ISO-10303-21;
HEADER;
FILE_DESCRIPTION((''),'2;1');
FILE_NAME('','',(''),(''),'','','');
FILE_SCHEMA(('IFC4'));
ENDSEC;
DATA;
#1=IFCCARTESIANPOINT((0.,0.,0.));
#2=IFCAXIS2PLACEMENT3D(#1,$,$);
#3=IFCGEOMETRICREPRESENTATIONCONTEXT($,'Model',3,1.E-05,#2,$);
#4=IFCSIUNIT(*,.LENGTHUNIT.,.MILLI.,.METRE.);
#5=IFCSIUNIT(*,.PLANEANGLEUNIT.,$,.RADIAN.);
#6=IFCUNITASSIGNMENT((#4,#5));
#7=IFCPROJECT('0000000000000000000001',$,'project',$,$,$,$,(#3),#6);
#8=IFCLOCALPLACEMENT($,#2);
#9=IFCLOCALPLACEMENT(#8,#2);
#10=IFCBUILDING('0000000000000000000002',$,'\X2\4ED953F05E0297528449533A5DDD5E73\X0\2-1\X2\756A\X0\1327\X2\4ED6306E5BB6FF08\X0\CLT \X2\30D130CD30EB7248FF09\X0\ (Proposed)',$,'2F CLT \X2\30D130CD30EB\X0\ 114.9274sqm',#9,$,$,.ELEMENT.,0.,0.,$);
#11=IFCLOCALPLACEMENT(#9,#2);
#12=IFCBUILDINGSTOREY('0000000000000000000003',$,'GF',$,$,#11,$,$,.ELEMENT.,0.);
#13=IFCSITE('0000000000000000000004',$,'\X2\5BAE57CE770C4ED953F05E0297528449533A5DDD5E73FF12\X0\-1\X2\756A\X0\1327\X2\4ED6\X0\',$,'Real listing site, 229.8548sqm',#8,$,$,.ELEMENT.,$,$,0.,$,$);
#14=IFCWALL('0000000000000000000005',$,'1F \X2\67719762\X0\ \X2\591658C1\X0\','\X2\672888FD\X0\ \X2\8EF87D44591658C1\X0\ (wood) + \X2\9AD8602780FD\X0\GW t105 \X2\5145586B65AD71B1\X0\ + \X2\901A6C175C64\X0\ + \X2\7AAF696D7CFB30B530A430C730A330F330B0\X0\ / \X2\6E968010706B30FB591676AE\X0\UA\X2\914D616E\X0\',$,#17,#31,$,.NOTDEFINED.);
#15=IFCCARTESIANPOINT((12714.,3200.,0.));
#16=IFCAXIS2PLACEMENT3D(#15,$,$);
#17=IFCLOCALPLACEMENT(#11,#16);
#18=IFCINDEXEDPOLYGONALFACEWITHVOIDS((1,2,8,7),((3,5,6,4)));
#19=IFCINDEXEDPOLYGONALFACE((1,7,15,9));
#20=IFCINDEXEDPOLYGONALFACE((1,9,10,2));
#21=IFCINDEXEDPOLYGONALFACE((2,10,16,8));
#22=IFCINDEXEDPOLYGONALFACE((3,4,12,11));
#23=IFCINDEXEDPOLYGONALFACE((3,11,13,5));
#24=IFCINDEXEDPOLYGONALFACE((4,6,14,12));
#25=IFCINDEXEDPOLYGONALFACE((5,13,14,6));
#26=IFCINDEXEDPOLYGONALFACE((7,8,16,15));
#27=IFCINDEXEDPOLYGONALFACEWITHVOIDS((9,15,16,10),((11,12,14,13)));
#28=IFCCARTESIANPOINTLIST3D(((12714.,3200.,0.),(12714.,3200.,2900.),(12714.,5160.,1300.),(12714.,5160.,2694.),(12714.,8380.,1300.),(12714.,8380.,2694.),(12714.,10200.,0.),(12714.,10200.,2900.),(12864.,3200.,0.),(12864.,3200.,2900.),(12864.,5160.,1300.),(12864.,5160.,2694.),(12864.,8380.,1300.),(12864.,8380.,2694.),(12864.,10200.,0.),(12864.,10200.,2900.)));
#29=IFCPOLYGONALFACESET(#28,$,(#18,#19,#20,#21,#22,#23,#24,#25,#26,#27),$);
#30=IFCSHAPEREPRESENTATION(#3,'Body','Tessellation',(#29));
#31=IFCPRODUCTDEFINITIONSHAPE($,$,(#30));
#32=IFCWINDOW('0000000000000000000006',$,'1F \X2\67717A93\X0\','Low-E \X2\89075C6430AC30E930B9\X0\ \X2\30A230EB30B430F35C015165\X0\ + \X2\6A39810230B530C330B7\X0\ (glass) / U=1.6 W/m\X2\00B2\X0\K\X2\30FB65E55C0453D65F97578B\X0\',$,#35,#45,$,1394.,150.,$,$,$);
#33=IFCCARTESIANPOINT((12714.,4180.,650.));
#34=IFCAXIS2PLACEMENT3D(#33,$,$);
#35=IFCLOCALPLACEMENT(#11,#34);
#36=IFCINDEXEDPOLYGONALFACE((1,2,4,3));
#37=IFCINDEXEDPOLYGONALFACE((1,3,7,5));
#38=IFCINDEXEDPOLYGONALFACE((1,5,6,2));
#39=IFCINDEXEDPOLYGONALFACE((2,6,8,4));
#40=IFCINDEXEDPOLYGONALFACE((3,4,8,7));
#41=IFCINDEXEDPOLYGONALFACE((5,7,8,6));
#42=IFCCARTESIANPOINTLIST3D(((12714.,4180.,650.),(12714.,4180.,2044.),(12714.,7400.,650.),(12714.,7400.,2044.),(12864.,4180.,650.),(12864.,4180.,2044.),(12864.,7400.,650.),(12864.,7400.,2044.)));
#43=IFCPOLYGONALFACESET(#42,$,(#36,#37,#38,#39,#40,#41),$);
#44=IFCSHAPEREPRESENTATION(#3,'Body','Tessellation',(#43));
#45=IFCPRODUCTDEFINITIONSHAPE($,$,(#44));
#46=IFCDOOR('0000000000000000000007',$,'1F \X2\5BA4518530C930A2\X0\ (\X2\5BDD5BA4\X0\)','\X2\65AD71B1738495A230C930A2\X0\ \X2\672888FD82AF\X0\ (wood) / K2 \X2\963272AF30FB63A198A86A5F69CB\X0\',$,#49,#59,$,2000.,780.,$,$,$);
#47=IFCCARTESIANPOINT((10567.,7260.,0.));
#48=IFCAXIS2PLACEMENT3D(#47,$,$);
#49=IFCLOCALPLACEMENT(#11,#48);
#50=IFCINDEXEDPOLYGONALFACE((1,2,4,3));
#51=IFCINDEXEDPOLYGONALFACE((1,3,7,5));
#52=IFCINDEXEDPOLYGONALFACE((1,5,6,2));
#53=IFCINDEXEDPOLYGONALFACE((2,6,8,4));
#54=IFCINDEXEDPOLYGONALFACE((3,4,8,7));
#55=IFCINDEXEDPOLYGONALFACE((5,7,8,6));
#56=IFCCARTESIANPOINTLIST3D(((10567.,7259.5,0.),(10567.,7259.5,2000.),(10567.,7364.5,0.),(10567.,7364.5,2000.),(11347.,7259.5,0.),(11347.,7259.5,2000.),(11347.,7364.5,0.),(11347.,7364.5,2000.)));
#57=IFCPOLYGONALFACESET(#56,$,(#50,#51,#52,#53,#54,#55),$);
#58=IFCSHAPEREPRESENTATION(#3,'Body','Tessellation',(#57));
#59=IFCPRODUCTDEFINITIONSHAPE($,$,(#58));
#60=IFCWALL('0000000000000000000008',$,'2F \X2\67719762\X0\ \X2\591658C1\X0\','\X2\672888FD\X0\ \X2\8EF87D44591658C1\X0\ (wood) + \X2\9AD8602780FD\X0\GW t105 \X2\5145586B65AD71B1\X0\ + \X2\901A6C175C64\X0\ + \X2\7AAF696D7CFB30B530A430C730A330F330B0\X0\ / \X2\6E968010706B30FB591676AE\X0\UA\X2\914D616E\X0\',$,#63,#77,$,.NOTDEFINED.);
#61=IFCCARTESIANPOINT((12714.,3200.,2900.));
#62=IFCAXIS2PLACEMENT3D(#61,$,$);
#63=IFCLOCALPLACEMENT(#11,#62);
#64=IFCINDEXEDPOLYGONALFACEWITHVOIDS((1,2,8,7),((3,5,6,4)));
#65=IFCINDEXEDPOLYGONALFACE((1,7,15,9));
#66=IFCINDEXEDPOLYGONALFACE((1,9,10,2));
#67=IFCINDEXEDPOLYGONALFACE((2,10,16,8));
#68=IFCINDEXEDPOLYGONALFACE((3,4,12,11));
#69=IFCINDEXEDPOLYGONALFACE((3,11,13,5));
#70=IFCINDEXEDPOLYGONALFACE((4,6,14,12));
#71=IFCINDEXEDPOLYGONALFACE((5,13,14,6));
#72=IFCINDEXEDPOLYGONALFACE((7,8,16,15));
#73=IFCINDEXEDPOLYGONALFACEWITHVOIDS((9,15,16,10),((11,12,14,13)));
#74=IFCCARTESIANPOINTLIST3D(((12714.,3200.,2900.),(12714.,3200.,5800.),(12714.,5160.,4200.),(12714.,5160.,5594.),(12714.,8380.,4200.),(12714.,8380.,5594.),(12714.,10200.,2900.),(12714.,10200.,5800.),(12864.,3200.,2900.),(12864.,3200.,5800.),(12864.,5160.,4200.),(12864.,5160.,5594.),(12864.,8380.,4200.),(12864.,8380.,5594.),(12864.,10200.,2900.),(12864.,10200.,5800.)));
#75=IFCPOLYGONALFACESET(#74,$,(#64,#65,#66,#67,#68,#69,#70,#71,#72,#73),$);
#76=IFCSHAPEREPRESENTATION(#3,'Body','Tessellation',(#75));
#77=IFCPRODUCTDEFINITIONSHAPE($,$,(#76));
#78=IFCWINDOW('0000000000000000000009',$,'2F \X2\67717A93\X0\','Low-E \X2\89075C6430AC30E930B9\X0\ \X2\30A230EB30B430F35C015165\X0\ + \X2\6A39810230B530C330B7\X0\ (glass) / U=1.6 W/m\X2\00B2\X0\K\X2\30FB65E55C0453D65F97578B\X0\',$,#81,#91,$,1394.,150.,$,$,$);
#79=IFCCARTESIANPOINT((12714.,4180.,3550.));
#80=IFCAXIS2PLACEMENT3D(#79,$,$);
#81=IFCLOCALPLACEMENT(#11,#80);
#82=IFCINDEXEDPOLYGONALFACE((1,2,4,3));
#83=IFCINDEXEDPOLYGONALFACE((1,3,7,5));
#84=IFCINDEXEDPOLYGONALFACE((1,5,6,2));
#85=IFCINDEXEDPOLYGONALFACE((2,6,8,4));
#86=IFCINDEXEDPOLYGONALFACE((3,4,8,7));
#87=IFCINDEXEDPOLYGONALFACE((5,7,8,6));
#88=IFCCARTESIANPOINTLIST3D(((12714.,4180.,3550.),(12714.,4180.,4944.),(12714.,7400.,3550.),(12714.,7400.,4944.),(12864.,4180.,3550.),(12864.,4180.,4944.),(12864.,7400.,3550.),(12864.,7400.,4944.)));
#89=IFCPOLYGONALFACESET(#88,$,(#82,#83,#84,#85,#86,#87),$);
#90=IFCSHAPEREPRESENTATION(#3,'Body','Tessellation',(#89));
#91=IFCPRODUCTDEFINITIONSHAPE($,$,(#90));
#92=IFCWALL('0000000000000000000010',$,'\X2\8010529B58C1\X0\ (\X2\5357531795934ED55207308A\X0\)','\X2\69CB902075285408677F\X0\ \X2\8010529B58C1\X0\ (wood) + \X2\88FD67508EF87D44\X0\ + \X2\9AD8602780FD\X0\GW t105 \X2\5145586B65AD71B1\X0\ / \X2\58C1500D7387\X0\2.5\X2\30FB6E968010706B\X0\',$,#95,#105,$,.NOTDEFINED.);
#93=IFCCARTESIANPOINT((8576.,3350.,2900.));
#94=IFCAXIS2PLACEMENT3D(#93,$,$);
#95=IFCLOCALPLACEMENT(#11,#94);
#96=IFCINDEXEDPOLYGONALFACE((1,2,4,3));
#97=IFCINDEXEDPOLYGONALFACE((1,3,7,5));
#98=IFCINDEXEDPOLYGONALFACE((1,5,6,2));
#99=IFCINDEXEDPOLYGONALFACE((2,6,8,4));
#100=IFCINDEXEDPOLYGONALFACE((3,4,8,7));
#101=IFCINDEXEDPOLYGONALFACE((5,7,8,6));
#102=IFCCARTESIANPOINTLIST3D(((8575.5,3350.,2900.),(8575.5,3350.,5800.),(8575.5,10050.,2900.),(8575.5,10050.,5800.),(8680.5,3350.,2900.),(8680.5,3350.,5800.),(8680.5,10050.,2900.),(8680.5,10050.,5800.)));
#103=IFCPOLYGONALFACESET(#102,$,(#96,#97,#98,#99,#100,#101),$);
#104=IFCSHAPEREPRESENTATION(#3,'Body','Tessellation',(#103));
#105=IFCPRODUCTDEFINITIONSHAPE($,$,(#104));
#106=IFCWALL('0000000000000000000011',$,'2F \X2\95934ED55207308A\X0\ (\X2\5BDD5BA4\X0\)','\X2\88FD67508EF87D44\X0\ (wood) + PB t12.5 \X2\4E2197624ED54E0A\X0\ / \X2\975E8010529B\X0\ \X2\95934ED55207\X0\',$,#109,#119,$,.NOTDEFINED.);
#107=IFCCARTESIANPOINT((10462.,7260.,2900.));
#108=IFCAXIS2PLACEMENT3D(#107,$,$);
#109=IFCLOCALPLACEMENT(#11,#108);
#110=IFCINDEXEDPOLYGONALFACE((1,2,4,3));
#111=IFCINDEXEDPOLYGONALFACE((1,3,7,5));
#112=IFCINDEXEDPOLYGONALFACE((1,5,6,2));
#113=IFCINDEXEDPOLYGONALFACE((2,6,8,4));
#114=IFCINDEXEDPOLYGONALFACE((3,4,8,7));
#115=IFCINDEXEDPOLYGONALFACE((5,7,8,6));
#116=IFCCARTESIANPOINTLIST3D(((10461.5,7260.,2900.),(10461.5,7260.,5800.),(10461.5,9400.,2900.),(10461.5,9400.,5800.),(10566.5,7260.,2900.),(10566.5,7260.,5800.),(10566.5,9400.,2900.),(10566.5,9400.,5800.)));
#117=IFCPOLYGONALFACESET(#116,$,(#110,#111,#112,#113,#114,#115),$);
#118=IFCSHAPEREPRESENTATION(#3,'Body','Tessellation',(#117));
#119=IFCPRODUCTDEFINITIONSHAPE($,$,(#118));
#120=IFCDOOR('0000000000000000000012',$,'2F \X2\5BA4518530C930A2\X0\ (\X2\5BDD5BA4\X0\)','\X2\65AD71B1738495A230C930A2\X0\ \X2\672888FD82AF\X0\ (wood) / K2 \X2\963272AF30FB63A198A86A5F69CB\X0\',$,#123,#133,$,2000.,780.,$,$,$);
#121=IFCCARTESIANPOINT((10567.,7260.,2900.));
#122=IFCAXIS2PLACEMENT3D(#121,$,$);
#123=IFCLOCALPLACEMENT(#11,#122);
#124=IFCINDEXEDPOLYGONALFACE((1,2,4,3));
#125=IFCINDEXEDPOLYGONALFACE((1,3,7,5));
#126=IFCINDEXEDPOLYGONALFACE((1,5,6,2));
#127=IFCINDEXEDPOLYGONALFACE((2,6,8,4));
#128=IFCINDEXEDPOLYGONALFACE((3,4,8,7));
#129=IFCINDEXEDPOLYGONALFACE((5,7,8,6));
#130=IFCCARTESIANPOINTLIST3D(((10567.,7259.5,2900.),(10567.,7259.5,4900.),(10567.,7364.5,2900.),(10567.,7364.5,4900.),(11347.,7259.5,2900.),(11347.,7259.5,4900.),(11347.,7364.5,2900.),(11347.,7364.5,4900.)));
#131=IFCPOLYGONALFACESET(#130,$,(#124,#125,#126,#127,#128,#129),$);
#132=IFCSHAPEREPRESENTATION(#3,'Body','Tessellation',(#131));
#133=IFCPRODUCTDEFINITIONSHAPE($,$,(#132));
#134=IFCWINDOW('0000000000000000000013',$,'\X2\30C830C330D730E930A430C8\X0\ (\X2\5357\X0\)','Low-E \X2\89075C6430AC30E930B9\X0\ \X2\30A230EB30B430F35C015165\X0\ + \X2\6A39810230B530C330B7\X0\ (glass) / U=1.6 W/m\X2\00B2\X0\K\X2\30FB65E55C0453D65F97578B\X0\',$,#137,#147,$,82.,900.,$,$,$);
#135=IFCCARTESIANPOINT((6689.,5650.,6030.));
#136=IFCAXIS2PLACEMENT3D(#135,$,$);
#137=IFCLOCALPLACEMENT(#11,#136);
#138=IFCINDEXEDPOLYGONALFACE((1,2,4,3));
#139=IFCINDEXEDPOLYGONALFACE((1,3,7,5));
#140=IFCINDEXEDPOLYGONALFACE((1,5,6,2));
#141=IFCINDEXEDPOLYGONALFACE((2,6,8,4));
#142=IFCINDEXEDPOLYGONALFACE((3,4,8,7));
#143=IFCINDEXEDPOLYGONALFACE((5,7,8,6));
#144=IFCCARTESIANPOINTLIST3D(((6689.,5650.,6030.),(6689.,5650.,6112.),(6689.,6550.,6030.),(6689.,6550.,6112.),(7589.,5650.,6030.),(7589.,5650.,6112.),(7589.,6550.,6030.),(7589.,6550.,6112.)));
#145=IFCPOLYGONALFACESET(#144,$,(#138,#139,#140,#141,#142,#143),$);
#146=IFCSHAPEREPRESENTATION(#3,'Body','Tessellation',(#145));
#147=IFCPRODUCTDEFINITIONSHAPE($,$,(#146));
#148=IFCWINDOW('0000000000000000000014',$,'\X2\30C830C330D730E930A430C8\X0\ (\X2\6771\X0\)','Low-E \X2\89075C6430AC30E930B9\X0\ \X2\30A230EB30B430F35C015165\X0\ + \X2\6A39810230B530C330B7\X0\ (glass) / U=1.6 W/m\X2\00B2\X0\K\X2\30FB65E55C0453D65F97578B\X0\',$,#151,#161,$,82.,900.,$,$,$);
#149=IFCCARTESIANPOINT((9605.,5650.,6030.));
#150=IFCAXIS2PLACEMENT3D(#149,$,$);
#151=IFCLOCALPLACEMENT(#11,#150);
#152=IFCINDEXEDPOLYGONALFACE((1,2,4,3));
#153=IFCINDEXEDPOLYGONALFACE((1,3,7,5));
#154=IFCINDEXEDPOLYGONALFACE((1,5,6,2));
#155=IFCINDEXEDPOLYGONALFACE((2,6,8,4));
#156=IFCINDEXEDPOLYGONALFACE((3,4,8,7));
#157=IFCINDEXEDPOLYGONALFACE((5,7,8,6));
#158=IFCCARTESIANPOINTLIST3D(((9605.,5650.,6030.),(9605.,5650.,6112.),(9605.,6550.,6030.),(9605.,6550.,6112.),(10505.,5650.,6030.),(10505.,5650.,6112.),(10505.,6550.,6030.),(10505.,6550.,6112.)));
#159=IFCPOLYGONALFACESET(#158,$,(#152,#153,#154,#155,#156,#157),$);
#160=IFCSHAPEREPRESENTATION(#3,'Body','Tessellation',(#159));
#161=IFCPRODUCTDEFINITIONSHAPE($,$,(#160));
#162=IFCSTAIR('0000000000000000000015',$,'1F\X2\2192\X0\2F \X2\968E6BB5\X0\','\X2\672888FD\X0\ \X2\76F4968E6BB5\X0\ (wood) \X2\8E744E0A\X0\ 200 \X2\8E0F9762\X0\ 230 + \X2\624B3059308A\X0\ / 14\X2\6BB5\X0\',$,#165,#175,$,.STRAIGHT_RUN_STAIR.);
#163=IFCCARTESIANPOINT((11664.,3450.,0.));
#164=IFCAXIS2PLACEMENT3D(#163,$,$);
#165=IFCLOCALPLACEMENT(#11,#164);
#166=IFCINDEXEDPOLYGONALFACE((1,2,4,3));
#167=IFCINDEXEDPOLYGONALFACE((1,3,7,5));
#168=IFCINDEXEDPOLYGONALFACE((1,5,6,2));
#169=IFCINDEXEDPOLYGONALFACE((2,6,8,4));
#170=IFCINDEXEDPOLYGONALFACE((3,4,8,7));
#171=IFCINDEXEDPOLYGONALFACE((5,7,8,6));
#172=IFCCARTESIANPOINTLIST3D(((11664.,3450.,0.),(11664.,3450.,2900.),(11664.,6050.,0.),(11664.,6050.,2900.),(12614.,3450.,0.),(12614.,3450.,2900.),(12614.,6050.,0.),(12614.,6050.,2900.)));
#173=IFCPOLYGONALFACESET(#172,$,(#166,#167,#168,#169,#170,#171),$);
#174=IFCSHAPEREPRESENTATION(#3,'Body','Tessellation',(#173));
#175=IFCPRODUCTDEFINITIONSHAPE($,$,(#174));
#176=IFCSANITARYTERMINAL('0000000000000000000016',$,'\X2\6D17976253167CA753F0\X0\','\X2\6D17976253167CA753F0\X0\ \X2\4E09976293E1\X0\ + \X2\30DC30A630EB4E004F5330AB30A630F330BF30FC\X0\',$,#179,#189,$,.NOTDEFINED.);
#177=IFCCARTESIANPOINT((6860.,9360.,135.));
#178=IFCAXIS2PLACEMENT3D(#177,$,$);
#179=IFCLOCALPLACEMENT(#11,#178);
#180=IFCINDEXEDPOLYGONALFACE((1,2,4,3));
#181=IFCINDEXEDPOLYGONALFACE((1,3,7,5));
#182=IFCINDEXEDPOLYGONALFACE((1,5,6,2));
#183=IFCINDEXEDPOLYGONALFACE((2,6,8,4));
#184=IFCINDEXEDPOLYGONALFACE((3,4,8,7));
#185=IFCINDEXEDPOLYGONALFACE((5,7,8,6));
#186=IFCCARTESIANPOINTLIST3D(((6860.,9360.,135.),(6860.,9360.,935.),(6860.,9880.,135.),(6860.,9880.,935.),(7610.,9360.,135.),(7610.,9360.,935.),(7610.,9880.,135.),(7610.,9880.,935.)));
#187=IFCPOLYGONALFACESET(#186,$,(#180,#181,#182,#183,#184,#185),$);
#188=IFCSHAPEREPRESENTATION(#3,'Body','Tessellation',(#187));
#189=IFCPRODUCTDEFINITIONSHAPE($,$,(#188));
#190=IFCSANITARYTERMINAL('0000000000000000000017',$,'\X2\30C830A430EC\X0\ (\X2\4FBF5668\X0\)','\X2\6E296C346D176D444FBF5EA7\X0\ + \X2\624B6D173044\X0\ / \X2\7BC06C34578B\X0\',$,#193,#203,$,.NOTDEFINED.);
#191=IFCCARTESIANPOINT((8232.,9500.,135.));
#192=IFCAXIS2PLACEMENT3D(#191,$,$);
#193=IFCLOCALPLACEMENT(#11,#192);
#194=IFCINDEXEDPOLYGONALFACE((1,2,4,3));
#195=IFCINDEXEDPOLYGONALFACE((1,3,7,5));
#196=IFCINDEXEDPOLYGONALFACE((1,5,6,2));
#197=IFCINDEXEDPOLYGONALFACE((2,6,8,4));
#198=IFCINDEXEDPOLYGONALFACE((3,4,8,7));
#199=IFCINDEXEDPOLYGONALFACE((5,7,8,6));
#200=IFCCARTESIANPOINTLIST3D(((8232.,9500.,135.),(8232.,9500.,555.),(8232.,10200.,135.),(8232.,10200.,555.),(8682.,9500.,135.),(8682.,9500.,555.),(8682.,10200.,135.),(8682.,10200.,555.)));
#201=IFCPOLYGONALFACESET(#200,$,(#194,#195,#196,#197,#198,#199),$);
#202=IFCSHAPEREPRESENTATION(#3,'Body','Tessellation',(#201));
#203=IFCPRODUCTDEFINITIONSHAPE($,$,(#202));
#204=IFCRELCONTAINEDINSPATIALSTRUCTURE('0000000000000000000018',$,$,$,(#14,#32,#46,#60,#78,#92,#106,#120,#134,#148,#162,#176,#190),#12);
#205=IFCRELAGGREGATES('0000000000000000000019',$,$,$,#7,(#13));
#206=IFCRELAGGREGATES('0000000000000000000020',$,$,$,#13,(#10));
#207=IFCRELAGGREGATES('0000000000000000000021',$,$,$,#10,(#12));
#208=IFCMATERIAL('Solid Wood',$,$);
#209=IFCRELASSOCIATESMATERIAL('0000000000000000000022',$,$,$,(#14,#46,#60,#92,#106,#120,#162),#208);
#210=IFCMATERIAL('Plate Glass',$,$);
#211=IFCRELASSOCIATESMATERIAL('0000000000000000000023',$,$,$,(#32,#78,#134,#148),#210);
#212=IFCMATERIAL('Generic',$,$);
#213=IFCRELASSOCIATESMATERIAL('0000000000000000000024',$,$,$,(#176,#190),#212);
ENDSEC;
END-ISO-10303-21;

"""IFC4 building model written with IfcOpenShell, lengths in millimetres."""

from ifc_helpers import new_model, si_unit, frame, frame_2d, origin, place, context, project, spatial, rectangle, extrude, material, element, fill, save


model = new_model("IFC4")

# Units and contexts
model_context = context("Model", 3, precision=1e-05, world=origin())
ifc_project = project(units=[si_unit("LENGTHUNIT", "METRE", prefix="MILLI"), si_unit("PLANEANGLEUNIT", "RADIAN")], contexts=[model_context])

# Site, building, storey
site_placement = place(None, origin())
site = spatial("IfcSite", under=ifc_project, at=site_placement, Name="宮城県仙台市青葉区川平２-1番1327他", ObjectType="Real listing site, 229.8548sqm", CompositionType="ELEMENT", RefElevation=0.0)
building_placement = place(site_placement, origin())
building = spatial("IfcBuilding", under=site, at=building_placement, Name="仙台市青葉区川平2-1番1327他の家（CLT パネル版） (Proposed)", ObjectType="2F CLT パネル 114.9274sqm", CompositionType="ELEMENT", ElevationOfRefHeight=0.0, ElevationOfTerrain=0.0)
storey_placement = place(building_placement, origin())
storey = spatial("IfcBuildingStorey", under=building, at=storey_placement, Name="GF", CompositionType="ELEMENT", Elevation=0.0)

# Wall, opening, window
ifc_material_1 = material(Name="Solid Wood")
wall_1_placement = place(storey_placement, frame((12714.0, 3200.0, 0.0)))
wall_1 = element("IfcWall", 1, at=wall_1_placement, inside=storey, material=ifc_material_1, Name="1F 東面 外壁", Description="木製 軸組外壁 (wood) + 高性能GW t105 充填断熱 + 通気層 + 窯業系サイディング / 準耐火・外皮UA配慮", PredefinedType="NOTDEFINED", context=model_context, shape_type="SweptSolid", body=[
    extrude(rectangle(XDim=150.0, YDim=7000.0, at=frame_2d((75.0, 3500.0))), frame((12714.0, 3200.0, 0.0)), (0.0, 0.0, 1.0), 2900.0),
])
opening_1_placement = place(storey_placement, frame((12714.0, 4180.0, 650.0)))
opening_1 = element("IfcOpeningElement", 2, at=opening_1_placement, cuts=wall_1, PredefinedType="NOTDEFINED", context=model_context, shape_type="SweptSolid", body=[
    extrude(rectangle(XDim=150.0, YDim=3220.0, at=frame_2d((75.0, 1610.0))), frame((12714.0, 4180.0, 650.0)), (0.0, 0.0, 1.0), 1394.0),
])
ifc_material_2 = material(Name="Plate Glass")
window_1_placement = place(storey_placement, frame((12714.0, 4180.0, 650.0)))
window_1 = element("IfcWindow", 3, at=window_1_placement, inside=storey, material=ifc_material_2, Name="1F 東窓", Description="Low-E 複層ガラス アルゴン封入 + 樹脂サッシ (glass) / U=1.6 W/m²K・日射取得型", OverallHeight=1394.0, OverallWidth=150.0, context=model_context, shape_type="SweptSolid", body=[
    extrude(rectangle(XDim=150.0, YDim=3220.0, at=frame_2d((75.0, 1610.0))), frame((12714.0, 4180.0, 650.0)), (0.0, 0.0, 1.0), 1394.0),
])
fill(opening_1, window_1)

# Door
door_1_placement = place(storey_placement, frame((10567.0, 7260.0, 0.0)))
element("IfcDoor", 4, at=door_1_placement, inside=storey, material=ifc_material_1, Name="1F 室内ドア (寝室)", Description="断熱玄関ドア 木製芯 (wood) / K2 防犯・採風機構", OverallHeight=2000.0, OverallWidth=780.0, context=model_context, shape_type="SweptSolid", body=[
    extrude(rectangle(XDim=780.0, YDim=105.0, at=frame_2d((390.0, 52.0))), frame((10567.0, 7260.0, 0.0)), (0.0, 0.0, 1.0), 2000.0),
])

# Wall, opening, window
wall_2_placement = place(storey_placement, frame((12714.0, 3200.0, 2900.0)))
wall_2 = element("IfcWall", 5, at=wall_2_placement, inside=storey, material=ifc_material_1, Name="2F 東面 外壁", Description="木製 軸組外壁 (wood) + 高性能GW t105 充填断熱 + 通気層 + 窯業系サイディング / 準耐火・外皮UA配慮", PredefinedType="NOTDEFINED", context=model_context, shape_type="SweptSolid", body=[
    extrude(rectangle(XDim=150.0, YDim=7000.0, at=frame_2d((75.0, 3500.0))), frame((12714.0, 3200.0, 2900.0)), (0.0, 0.0, 1.0), 2900.0),
])
opening_2_placement = place(storey_placement, frame((12714.0, 4180.0, 3550.0)))
opening_2 = element("IfcOpeningElement", 6, at=opening_2_placement, cuts=wall_2, PredefinedType="NOTDEFINED", context=model_context, shape_type="SweptSolid", body=[
    extrude(rectangle(XDim=150.0, YDim=3220.0, at=frame_2d((75.0, 1610.0))), frame((12714.0, 4180.0, 3550.0)), (0.0, 0.0, 1.0), 1394.0),
])
window_2_placement = place(storey_placement, frame((12714.0, 4180.0, 3550.0)))
window_2 = element("IfcWindow", 7, at=window_2_placement, inside=storey, material=ifc_material_2, Name="2F 東窓", Description="Low-E 複層ガラス アルゴン封入 + 樹脂サッシ (glass) / U=1.6 W/m²K・日射取得型", OverallHeight=1394.0, OverallWidth=150.0, context=model_context, shape_type="SweptSolid", body=[
    extrude(rectangle(XDim=150.0, YDim=3220.0, at=frame_2d((75.0, 1610.0))), frame((12714.0, 4180.0, 3550.0)), (0.0, 0.0, 1.0), 1394.0),
])
fill(opening_2, window_2)

# Walls
wall_3_placement = place(storey_placement, frame((8576.0, 3350.0, 2900.0)))
element("IfcWall", 8, at=wall_3_placement, inside=storey, material=ifc_material_1, Name="耐力壁 (南北間仕切り)", Description="構造用合板 耐力壁 (wood) + 製材軸組 + 高性能GW t105 充填断熱 / 壁倍率2.5・準耐火", PredefinedType="NOTDEFINED", context=model_context, shape_type="SweptSolid", body=[
    extrude(rectangle(XDim=105.0, YDim=6700.0, at=frame_2d((52.0, 3350.0))), frame((8576.0, 3350.0, 2900.0)), (0.0, 0.0, 1.0), 2900.0),
])
wall_4_placement = place(storey_placement, frame((10462.0, 7260.0, 2900.0)))
element("IfcWall", 9, at=wall_4_placement, inside=storey, material=ifc_material_1, Name="2F 間仕切り (寝室)", Description="製材軸組 (wood) + PB t12.5 両面仕上 / 非耐力 間仕切", PredefinedType="NOTDEFINED", context=model_context, shape_type="SweptSolid", body=[
    extrude(rectangle(XDim=105.0, YDim=2140.0, at=frame_2d((52.0, 1070.0))), frame((10462.0, 7260.0, 2900.0)), (0.0, 0.0, 1.0), 2900.0),
])

# Door
door_2_placement = place(storey_placement, frame((10567.0, 7260.0, 2900.0)))
element("IfcDoor", 10, at=door_2_placement, inside=storey, material=ifc_material_1, Name="2F 室内ドア (寝室)", Description="断熱玄関ドア 木製芯 (wood) / K2 防犯・採風機構", OverallHeight=2000.0, OverallWidth=780.0, context=model_context, shape_type="SweptSolid", body=[
    extrude(rectangle(XDim=780.0, YDim=105.0, at=frame_2d((390.0, 52.0))), frame((10567.0, 7260.0, 2900.0)), (0.0, 0.0, 1.0), 2000.0),
])

# Windows
window_3_placement = place(storey_placement, frame((6689.0, 5650.0, 6030.0)))
element("IfcWindow", 11, at=window_3_placement, inside=storey, material=ifc_material_2, Name="トップライト (南)", Description="Low-E 複層ガラス アルゴン封入 + 樹脂サッシ (glass) / U=1.6 W/m²K・日射取得型", OverallHeight=82.0, OverallWidth=900.0, context=model_context, shape_type="SweptSolid", body=[
    extrude(rectangle(XDim=900.0, YDim=900.0, at=frame_2d((450.0, 450.0))), frame((6689.0, 5650.0, 6030.0)), (0.0, 0.0, 1.0), 82.0),
])
window_4_placement = place(storey_placement, frame((9605.0, 5650.0, 6030.0)))
element("IfcWindow", 12, at=window_4_placement, inside=storey, material=ifc_material_2, Name="トップライト (東)", Description="Low-E 複層ガラス アルゴン封入 + 樹脂サッシ (glass) / U=1.6 W/m²K・日射取得型", OverallHeight=82.0, OverallWidth=900.0, context=model_context, shape_type="SweptSolid", body=[
    extrude(rectangle(XDim=900.0, YDim=900.0, at=frame_2d((450.0, 450.0))), frame((9605.0, 5650.0, 6030.0)), (0.0, 0.0, 1.0), 82.0),
])

# Stair
stair_placement = place(storey_placement, frame((11664.0, 3450.0, 0.0)))
element("IfcStair", 13, at=stair_placement, inside=storey, material=ifc_material_1, Name="1F→2F 階段", Description="木製 直階段 (wood) 蹴上 200 踏面 230 + 手すり / 14段", PredefinedType="STRAIGHT_RUN_STAIR", context=model_context, shape_type="SweptSolid", body=[
    extrude(rectangle(XDim=950.0, YDim=2600.0, at=frame_2d((475.0, 1300.0))), frame((11664.0, 3450.0, 0.0)), (0.0, 0.0, 1.0), 2900.0),
])

# Sanitary terminals
ifc_material_3 = material(Name="Generic")
sanitary_terminal_1_placement = place(storey_placement, frame((6860.0, 9360.0, 135.0)))
element("IfcSanitaryTerminal", 14, at=sanitary_terminal_1_placement, inside=storey, material=ifc_material_3, Name="洗面化粧台", Description="洗面化粧台 三面鏡 + ボウル一体カウンター", PredefinedType="NOTDEFINED", context=model_context, shape_type="SweptSolid", body=[
    extrude(rectangle(XDim=750.0, YDim=520.0, at=frame_2d((375.0, 260.0))), frame((6860.0, 9360.0, 135.0)), (0.0, 0.0, 1.0), 800.0),
])
sanitary_terminal_2_placement = place(storey_placement, frame((8232.0, 9500.0, 135.0)))
element("IfcSanitaryTerminal", 15, at=sanitary_terminal_2_placement, inside=storey, material=ifc_material_3, Name="トイレ (便器)", Description="温水洗浄便座 + 手洗い / 節水型", PredefinedType="NOTDEFINED", context=model_context, shape_type="SweptSolid", body=[
    extrude(rectangle(XDim=450.0, YDim=700.0, at=frame_2d((225.0, 350.0))), frame((8232.0, 9500.0, 135.0)), (0.0, 0.0, 1.0), 420.0),
])

save(model, "model.ifc")
